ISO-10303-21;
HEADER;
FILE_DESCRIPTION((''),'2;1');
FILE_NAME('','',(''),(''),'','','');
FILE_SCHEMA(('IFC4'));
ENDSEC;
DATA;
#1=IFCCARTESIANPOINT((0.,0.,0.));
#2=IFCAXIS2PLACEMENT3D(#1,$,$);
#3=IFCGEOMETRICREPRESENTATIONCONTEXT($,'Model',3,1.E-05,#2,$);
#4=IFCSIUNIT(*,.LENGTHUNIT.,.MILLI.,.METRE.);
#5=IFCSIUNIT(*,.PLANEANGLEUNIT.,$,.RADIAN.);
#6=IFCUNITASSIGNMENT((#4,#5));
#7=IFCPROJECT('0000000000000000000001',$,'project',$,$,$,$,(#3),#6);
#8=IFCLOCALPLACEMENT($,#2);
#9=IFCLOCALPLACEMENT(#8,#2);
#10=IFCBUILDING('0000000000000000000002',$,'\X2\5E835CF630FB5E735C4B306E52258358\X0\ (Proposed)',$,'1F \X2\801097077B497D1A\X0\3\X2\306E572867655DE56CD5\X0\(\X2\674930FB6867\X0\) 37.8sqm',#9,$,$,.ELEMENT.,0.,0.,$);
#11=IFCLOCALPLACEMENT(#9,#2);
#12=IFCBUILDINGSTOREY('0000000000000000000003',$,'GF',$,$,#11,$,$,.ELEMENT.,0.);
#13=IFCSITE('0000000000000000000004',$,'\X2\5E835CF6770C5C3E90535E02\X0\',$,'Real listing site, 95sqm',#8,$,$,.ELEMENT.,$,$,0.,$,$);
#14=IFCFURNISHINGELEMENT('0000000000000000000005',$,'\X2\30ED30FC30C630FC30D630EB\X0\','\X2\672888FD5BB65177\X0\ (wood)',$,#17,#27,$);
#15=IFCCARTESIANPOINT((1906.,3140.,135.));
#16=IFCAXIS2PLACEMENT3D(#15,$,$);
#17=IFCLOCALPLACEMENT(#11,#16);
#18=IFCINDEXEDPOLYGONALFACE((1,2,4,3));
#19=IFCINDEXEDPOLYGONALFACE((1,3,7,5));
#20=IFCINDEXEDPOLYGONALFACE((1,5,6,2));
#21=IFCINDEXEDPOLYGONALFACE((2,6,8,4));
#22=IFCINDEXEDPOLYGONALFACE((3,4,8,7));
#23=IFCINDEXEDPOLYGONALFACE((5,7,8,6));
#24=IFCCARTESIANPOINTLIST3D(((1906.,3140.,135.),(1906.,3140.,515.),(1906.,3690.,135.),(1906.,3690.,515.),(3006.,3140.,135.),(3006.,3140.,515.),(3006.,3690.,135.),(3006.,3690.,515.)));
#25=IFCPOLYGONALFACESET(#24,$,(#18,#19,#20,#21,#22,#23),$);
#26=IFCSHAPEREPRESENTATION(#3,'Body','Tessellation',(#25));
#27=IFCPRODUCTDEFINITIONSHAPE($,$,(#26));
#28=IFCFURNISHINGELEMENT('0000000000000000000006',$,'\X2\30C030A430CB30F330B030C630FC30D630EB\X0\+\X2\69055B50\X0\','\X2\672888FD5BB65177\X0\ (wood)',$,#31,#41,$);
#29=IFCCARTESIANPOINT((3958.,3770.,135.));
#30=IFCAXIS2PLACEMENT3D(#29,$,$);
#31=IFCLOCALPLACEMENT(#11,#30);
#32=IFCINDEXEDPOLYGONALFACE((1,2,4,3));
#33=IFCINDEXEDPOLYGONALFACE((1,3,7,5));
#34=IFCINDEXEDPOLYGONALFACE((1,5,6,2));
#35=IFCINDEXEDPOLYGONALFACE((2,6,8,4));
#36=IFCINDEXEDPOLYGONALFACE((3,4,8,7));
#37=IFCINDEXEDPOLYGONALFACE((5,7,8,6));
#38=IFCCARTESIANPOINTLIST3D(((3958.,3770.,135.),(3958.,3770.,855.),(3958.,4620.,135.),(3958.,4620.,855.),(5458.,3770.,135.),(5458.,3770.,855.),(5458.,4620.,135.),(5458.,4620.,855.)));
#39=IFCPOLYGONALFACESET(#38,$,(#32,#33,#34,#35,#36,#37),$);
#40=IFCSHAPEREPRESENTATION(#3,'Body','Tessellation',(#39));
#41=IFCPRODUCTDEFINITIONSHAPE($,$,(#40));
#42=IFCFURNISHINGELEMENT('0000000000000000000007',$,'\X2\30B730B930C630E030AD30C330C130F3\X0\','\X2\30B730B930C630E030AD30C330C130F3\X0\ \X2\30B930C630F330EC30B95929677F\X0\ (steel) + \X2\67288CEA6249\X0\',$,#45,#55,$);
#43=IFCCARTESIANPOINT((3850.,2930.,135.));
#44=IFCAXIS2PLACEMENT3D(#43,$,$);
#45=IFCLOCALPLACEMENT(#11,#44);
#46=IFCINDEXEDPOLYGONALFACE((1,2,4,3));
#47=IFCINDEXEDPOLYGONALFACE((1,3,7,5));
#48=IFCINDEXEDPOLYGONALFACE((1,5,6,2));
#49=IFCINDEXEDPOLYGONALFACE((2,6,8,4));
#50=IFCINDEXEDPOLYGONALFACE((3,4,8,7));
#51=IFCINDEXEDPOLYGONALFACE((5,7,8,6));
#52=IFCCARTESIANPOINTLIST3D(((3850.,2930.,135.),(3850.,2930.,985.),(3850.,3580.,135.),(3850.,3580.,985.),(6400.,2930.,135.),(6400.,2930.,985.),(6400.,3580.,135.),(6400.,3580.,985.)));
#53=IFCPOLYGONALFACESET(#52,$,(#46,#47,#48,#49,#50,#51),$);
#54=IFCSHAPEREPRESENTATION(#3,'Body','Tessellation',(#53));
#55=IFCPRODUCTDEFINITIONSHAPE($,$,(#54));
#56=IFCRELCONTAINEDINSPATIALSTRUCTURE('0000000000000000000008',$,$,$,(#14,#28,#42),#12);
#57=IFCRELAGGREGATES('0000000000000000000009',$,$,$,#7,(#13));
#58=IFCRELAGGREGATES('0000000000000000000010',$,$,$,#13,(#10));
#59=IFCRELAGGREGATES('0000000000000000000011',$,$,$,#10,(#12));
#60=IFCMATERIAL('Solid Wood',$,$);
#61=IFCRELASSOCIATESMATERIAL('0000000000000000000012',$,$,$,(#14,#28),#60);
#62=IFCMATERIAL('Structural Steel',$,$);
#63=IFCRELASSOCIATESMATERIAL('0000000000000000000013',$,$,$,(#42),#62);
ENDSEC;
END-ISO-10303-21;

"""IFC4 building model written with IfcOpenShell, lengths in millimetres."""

from ifc_helpers import new_model, si_unit, frame, frame_2d, origin, place, context, project, spatial, rectangle, extrude, material, element, save


model = new_model("IFC4")

# Units and contexts
model_context = context("Model", 3, precision=1e-05, world=origin())
ifc_project = project(units=[si_unit("LENGTHUNIT", "METRE", prefix="MILLI"), si_unit("PLANEANGLEUNIT", "RADIAN")], contexts=[model_context])

# Site, building, storey
site_placement = place(None, origin())
site = spatial("IfcSite", under=ifc_project, at=site_placement, Name="広島県尾道市", ObjectType="Real listing site, 95sqm", CompositionType="ELEMENT", RefElevation=0.0)
building_placement = place(site_placement, origin())
building = spatial("IfcBuilding", under=site, at=building_placement, Name="広島・平屋の別荘 (Proposed)", ObjectType="1F 耐震等級3の在来工法(杉・桧) 37.8sqm", CompositionType="ELEMENT", ElevationOfRefHeight=0.0, ElevationOfTerrain=0.0)
storey_placement = place(building_placement, origin())
storey = spatial("IfcBuildingStorey", under=building, at=storey_placement, Name="GF", CompositionType="ELEMENT", Elevation=0.0)

# Shared definitions
ifc_material_1 = material(Name="Solid Wood")

# Shared definitions
ifc_material_2 = material(Name="Structural Steel")

# Furnishing elements
furnishing_1_placement = place(storey_placement, frame((1906.0, 3140.0, 135.0)))
element("IfcFurnishingElement", 1, at=furnishing_1_placement, inside=storey, material=ifc_material_1, Name="ローテーブル", Description="木製家具 (wood)", context=model_context, shape_type="SweptSolid", body=[
    extrude(rectangle(XDim=1100.0, YDim=550.0, at=frame_2d((550.0, 275.0))), frame((1906.0, 3140.0, 135.0)), (0.0, 0.0, 1.0), 380.0),
])
furnishing_2_placement = place(storey_placement, frame((3958.0, 3770.0, 135.0)))
element("IfcFurnishingElement", 2, at=furnishing_2_placement, inside=storey, material=ifc_material_1, Name="ダイニングテーブル+椅子", Description="木製家具 (wood)", context=model_context, shape_type="SweptSolid", body=[
    extrude(rectangle(XDim=1500.0, YDim=850.0, at=frame_2d((750.0, 425.0))), frame((3958.0, 3770.0, 135.0)), (0.0, 0.0, 1.0), 720.0),
])
furnishing_3_placement = place(storey_placement, frame((3850.0, 2930.0, 135.0)))
element("IfcFurnishingElement", 3, at=furnishing_3_placement, inside=storey, material=ifc_material_2, Name="システムキッチン", Description="システムキッチン ステンレス天板 (steel) + 木質扉", context=model_context, shape_type="SweptSolid", body=[
    extrude(rectangle(XDim=2550.0, YDim=650.0, at=frame_2d((1275.0, 325.0))), frame((3850.0, 2930.0, 135.0)), (0.0, 0.0, 1.0), 850.0),
])

save(model, "model.ifc")
